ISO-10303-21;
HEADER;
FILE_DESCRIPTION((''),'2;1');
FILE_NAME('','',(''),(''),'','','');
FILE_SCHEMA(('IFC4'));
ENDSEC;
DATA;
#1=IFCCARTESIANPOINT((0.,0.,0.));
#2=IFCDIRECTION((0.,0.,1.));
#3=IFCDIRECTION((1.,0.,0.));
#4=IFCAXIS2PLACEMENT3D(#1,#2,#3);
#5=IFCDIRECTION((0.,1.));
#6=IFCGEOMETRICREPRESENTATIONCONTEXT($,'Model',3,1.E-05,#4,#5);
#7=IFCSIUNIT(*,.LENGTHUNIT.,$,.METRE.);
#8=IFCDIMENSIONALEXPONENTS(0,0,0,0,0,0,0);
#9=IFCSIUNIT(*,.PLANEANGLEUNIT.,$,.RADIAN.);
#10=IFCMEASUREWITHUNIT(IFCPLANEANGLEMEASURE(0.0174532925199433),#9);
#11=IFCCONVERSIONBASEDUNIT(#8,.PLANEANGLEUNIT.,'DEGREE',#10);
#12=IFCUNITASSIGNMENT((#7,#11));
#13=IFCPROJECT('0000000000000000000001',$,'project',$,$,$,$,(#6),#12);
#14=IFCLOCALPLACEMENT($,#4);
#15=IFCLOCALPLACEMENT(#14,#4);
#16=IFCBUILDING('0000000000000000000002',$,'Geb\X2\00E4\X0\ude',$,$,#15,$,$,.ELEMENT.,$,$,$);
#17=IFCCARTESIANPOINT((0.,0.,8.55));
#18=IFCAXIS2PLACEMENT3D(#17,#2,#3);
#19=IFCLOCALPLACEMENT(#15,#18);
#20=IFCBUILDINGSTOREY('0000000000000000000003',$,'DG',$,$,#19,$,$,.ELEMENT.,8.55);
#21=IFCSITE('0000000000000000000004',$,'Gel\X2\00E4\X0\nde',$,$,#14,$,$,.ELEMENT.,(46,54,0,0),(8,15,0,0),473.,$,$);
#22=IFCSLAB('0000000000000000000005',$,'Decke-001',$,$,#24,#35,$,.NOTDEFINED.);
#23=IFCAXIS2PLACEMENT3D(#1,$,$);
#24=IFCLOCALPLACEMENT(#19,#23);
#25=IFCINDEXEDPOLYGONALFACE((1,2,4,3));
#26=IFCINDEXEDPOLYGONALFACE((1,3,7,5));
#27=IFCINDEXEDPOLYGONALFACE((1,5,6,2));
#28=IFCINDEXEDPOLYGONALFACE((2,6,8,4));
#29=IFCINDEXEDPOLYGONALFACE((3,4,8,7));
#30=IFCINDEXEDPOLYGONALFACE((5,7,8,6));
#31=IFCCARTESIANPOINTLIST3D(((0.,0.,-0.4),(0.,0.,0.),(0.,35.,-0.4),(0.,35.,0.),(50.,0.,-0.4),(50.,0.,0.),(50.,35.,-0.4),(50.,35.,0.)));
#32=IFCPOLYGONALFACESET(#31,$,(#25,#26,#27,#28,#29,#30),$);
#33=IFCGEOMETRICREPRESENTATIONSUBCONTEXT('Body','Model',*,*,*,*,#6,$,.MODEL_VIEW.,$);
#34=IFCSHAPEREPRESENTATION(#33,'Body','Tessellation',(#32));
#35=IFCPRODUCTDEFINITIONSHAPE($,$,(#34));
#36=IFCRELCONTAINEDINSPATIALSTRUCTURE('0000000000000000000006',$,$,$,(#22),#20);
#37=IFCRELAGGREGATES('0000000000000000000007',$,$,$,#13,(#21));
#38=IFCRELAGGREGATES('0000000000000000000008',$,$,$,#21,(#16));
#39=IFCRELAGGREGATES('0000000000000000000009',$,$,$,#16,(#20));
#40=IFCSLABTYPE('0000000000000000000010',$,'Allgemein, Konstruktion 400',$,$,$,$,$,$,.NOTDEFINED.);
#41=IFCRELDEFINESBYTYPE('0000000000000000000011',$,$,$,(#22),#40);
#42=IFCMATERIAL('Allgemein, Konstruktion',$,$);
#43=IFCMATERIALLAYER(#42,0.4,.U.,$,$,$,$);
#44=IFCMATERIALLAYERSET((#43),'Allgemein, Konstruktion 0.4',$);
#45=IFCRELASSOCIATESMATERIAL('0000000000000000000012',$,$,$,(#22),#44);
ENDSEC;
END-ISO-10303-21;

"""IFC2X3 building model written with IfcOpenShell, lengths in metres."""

from ifc_helpers import new_model, entity, si_unit, converted_unit, direction, frame, origin_with_axes, place, context, subcontext, project, spatial, polyline, outline, extrude, material, layer, layer_set, layer_usage, type_object, element, save


model = new_model("IFC2X3")

# Units and contexts
model_context = context("Model", 3, precision=1e-05, world=origin_with_axes(), true_north=direction((0.0, 1.0)))
body_context = subcontext(model_context, "Body", "Model", "MODEL_VIEW")
ifc_project = project(units=[si_unit("LENGTHUNIT", "METRE"), converted_unit("PLANEANGLEUNIT", "DEGREE", entity("IfcPlaneAngleMeasure", 0.0174532925199433), si_unit("PLANEANGLEUNIT", "RADIAN"), dimensions=[0, 0, 0, 0, 0, 0, 0])], contexts=[model_context])

# Site, building, storey
site_placement = place(None, origin_with_axes())
site = spatial("IfcSite", under=ifc_project, at=site_placement, Name="Gelände", CompositionType="ELEMENT", RefLatitude=(46, 54, 0, 0), RefLongitude=(8, 15, 0, 0), RefElevation=473.0)
building_placement = place(site_placement, origin_with_axes())
building = spatial("IfcBuilding", under=site, at=building_placement, Name="Gebäude", CompositionType="ELEMENT")
storey_placement = place(building_placement, frame((0.0, 0.0, 8.55), z_axis=(0.0, 0.0, 1.0), x_axis=(1.0, 0.0, 0.0)))
storey = spatial("IfcBuildingStorey", under=building, at=storey_placement, Name="DG", CompositionType="ELEMENT", Elevation=8.55)

# Slab
ifc_material = material(Name="Allgemein, Konstruktion")
ifc_layer = layer(ifc_material, 0.4, ventilated="UNKNOWN")
ifc_layer_set = layer_set([ifc_layer], Name="Allgemein, Konstruktion 0.4")
ifc_layer_usage = layer_usage(ifc_layer_set, "AXIS3", "NEGATIVE", 0.4)
slab_type = type_object("IfcSlabType", Name="Allgemein, Konstruktion 400", PredefinedType="NOTDEFINED")
slab_placement = place(storey_placement, origin_with_axes())
element("IfcSlab", 1, at=slab_placement, inside=storey, type_object=slab_type, material=ifc_layer_usage, Name="Decke-001", PredefinedType="NOTDEFINED", context=body_context, shape_type="SweptSolid", body=[
    extrude(outline(polyline([(0.0, 0.0), (50.0, 0.0), (50.0, 35.0), (0.0, 35.0), (0.0, 0.0)])), frame((0.0, 0.0, -0.4), z_axis=(0.0, 0.0, 1.0), x_axis=(1.0, 0.0, 0.0)), (0.0, 0.0, 1.0), 0.4),
])

save(model, "model.ifc")
